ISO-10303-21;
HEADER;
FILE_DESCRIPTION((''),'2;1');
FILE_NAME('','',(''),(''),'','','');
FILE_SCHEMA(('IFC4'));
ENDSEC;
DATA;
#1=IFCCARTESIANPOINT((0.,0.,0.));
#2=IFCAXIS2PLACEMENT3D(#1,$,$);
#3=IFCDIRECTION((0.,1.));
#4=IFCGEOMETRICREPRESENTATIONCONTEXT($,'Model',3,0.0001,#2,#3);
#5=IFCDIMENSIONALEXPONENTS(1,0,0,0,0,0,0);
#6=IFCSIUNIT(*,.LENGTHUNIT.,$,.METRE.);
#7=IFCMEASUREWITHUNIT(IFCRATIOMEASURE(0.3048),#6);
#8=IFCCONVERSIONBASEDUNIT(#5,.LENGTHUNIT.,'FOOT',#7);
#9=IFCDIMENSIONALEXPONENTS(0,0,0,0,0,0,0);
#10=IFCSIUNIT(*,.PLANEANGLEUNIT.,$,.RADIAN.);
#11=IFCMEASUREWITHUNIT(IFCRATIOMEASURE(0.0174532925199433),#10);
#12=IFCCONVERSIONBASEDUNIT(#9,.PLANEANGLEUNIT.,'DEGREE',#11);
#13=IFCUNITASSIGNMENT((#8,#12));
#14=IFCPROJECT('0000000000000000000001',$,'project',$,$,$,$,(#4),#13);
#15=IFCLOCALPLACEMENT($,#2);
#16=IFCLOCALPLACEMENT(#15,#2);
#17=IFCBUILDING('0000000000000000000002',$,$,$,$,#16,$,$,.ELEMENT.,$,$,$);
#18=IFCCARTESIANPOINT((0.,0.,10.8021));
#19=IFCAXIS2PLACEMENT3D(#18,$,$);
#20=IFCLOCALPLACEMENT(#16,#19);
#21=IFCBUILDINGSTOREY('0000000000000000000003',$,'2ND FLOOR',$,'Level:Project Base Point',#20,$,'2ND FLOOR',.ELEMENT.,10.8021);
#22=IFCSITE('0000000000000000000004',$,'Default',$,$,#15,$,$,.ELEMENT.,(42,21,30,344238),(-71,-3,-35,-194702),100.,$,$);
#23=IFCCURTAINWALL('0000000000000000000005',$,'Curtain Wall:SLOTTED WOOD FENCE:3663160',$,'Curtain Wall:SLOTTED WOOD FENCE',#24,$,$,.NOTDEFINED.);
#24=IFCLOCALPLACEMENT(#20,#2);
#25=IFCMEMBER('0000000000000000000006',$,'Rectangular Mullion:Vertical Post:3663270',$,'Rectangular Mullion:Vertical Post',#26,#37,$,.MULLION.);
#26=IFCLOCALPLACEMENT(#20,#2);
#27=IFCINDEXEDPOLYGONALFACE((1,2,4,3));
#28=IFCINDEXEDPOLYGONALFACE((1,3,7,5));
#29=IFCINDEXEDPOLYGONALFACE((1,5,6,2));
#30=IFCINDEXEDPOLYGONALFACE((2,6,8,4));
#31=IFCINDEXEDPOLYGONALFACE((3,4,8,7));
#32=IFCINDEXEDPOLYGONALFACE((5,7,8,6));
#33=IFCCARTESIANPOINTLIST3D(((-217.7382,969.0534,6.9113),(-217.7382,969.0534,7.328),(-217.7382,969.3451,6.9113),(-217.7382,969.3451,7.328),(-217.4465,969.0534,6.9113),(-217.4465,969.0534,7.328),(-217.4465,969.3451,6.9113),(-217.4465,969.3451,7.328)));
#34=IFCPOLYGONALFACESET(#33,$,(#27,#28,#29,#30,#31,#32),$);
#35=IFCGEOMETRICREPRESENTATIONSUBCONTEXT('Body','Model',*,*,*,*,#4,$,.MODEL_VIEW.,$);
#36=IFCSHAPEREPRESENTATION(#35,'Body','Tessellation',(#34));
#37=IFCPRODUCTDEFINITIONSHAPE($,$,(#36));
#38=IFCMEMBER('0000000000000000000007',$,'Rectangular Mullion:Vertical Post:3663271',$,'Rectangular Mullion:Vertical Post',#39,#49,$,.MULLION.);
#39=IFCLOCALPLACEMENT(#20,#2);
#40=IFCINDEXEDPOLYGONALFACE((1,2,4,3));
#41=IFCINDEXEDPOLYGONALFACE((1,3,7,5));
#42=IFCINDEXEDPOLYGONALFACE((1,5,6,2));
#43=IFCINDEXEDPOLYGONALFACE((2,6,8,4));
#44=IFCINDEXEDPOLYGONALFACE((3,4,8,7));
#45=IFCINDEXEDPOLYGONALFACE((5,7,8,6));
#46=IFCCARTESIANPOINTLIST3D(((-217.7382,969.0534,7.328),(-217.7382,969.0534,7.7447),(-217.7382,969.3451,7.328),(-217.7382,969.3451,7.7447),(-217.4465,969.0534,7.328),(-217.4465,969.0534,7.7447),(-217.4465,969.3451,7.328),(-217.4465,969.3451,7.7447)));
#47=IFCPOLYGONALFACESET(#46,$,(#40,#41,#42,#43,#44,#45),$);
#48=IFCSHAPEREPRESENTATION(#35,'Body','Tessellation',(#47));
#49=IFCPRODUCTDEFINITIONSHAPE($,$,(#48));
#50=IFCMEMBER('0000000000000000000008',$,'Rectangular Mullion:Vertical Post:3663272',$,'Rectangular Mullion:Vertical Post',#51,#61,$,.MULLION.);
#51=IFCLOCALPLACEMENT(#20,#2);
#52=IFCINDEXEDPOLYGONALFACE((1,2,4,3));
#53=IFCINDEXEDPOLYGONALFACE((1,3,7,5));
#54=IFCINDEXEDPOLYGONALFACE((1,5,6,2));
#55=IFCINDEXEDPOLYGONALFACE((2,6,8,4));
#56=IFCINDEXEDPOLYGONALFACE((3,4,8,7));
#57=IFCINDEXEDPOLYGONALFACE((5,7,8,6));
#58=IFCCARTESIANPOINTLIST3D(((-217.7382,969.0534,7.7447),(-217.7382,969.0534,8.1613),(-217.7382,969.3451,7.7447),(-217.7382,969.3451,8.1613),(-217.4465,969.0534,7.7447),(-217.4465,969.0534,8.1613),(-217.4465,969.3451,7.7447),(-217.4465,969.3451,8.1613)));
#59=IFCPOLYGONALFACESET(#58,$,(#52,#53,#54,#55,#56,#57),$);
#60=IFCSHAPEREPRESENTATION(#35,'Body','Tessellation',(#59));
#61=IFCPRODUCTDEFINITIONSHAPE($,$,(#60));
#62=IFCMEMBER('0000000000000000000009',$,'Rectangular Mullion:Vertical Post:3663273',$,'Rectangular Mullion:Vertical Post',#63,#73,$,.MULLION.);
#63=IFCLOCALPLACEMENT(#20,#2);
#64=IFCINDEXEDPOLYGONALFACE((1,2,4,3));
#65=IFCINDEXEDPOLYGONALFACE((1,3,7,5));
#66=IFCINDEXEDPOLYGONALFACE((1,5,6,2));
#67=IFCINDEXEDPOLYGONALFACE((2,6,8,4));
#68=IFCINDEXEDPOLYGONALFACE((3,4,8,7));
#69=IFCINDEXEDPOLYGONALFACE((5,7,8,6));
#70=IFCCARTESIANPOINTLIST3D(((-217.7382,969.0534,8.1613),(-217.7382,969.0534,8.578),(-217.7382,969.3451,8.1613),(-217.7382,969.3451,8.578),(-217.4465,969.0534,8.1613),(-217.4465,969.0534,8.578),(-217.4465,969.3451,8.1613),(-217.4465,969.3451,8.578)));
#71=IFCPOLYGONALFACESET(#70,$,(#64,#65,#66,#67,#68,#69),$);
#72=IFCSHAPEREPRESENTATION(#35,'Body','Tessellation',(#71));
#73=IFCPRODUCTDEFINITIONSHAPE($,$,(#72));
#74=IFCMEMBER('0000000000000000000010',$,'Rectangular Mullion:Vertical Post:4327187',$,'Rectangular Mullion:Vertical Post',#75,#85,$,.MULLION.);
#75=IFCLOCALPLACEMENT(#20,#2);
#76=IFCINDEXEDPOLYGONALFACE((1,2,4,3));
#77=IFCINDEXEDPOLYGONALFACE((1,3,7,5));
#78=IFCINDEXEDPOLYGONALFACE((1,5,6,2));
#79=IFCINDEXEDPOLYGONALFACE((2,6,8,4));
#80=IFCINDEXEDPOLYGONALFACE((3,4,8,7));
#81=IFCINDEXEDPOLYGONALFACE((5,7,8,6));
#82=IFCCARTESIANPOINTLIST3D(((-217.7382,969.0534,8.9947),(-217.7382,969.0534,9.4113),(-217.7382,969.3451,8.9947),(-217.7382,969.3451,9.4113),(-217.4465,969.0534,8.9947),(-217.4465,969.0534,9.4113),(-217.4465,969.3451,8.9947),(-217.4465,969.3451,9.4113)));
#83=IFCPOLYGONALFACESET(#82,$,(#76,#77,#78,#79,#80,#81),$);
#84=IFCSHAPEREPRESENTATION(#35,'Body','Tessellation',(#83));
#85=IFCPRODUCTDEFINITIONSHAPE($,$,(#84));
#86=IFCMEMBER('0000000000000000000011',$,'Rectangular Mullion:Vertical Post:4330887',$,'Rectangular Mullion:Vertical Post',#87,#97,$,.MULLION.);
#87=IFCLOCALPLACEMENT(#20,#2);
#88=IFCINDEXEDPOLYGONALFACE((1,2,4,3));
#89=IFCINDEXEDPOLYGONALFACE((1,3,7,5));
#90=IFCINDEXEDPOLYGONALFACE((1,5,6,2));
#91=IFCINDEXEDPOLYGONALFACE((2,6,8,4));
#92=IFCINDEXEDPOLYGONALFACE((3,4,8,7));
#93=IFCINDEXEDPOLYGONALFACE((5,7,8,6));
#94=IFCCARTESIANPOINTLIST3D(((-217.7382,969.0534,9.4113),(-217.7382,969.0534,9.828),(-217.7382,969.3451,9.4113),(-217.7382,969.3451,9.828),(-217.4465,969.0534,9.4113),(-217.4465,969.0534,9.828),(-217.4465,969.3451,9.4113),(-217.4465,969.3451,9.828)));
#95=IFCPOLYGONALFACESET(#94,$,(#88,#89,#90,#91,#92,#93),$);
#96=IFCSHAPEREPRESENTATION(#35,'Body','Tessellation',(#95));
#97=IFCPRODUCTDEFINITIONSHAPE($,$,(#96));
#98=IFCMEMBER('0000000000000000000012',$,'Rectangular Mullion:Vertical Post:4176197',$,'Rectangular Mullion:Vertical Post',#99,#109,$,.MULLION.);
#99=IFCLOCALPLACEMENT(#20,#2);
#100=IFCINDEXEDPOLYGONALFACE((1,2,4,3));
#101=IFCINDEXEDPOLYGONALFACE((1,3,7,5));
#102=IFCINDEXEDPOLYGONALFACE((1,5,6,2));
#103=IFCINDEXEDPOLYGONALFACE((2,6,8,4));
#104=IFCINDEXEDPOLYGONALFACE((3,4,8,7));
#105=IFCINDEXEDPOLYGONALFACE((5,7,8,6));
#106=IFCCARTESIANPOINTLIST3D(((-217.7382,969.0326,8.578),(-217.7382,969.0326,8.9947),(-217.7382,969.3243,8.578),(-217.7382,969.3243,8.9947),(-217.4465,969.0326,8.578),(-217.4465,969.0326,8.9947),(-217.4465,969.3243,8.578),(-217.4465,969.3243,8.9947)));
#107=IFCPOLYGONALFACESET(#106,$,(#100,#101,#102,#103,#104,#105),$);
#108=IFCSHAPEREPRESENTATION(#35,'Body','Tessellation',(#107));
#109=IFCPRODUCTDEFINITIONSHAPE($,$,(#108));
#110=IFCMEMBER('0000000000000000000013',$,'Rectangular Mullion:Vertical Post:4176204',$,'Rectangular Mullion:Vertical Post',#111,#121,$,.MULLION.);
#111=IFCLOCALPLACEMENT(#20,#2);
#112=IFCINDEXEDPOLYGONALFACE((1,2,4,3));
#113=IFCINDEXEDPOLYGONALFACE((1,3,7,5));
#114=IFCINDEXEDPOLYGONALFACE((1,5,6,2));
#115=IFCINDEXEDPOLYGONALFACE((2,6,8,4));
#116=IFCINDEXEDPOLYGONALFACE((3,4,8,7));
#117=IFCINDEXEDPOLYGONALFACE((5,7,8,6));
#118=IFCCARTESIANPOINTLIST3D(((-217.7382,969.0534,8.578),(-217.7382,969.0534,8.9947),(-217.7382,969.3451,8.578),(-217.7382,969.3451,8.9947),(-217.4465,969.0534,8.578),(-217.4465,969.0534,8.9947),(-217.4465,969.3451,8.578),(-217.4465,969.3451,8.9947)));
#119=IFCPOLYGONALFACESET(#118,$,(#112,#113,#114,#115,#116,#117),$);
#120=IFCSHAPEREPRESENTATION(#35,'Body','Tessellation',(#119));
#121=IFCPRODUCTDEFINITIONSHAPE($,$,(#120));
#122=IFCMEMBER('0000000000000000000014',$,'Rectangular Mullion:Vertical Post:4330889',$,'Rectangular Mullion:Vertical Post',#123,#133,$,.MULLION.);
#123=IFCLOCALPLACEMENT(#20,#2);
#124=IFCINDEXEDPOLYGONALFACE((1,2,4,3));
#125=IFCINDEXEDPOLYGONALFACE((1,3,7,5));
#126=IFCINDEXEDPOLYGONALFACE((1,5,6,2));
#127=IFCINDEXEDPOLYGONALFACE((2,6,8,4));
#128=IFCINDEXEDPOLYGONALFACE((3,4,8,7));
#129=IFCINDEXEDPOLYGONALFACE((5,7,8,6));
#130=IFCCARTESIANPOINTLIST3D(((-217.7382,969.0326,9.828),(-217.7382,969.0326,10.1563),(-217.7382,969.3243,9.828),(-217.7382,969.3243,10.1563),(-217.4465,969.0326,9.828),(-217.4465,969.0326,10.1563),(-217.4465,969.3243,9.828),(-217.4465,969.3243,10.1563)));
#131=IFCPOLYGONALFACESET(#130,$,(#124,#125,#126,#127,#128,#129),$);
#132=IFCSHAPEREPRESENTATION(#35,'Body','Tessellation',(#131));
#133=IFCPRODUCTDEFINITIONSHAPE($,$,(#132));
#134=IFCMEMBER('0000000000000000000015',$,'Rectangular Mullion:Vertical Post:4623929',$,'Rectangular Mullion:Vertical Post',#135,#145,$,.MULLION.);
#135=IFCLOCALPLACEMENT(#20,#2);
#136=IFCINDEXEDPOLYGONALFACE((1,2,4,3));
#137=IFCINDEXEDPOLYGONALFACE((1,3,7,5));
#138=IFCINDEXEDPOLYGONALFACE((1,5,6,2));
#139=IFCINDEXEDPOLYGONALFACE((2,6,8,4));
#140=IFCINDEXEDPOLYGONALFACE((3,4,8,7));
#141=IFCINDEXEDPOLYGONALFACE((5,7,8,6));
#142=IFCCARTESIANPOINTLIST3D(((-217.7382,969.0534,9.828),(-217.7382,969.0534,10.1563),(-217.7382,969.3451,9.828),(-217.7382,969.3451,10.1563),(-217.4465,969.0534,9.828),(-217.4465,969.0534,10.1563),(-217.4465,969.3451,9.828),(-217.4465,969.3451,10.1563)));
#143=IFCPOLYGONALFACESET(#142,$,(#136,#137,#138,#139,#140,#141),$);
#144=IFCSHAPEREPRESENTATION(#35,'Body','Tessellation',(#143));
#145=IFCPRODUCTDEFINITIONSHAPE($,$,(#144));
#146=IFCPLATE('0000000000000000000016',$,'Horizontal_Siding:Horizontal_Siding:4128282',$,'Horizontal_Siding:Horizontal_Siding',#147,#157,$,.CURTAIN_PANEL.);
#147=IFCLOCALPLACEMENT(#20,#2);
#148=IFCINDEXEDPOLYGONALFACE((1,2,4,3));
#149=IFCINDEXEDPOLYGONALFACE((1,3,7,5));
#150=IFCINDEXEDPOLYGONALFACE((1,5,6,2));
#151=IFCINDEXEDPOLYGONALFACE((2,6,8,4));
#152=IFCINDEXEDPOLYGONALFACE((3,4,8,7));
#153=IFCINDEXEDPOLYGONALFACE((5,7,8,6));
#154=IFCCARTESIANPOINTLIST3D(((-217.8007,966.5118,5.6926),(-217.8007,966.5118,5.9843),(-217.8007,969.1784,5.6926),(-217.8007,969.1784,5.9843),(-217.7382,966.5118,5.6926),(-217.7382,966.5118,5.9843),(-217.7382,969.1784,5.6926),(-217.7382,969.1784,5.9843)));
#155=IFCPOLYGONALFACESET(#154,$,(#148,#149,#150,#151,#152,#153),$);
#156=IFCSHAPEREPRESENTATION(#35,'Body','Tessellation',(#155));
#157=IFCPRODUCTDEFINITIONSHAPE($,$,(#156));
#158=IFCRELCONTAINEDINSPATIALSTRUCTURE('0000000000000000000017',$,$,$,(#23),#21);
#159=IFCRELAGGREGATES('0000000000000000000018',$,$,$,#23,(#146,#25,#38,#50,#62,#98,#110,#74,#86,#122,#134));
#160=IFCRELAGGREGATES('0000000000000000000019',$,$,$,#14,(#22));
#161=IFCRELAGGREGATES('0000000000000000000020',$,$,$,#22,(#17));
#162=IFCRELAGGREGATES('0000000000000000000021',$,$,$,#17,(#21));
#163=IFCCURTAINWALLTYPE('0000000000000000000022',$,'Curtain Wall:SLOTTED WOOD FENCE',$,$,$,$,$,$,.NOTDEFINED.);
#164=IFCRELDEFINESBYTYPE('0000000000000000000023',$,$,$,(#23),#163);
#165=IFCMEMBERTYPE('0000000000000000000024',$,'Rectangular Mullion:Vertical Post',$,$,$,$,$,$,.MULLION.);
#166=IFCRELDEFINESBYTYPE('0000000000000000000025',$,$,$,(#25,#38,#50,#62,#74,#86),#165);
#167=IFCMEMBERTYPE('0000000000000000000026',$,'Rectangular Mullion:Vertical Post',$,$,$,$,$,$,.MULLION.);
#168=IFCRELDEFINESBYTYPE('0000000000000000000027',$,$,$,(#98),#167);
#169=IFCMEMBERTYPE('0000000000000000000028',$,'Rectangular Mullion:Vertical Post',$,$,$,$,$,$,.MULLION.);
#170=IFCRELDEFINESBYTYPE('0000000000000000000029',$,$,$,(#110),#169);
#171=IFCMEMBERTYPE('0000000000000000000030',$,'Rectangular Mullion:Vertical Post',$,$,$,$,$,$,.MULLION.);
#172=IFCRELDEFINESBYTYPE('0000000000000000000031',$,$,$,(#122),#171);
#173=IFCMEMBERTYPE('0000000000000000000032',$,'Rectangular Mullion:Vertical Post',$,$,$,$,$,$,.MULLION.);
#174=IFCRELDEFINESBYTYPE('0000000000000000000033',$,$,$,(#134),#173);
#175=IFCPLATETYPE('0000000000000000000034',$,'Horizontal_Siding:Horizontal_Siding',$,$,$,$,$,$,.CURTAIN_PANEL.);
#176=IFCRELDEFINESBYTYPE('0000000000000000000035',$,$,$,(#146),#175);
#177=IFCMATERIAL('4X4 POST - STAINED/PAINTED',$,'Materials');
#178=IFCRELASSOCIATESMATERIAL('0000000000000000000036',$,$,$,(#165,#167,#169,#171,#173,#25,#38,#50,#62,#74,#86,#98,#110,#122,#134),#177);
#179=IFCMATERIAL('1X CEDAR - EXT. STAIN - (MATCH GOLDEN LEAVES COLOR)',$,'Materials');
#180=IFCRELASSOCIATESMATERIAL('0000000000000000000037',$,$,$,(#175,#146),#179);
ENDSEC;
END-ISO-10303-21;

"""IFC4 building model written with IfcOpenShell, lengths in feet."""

from ifc_helpers import new_model, entity, si_unit, converted_unit, direction, frame, origin, origin_2d_with_axis, place, context, subcontext, project, spatial, rectangle, extrude, source, transform, mapped, material, material_profile, profile_set, profile_usage, type_object, type_shapes, element, aggregate, save


model = new_model("IFC4")

# Units and contexts
model_context = context("Model", 3, precision=0.0001, world=origin(), true_north=direction((0.0, 1.0)))
body_context = subcontext(model_context, "Body", "Model", "MODEL_VIEW")
ifc_project = project(units=[converted_unit("LENGTHUNIT", "FOOT", entity("IfcRatioMeasure", 0.3048), si_unit("LENGTHUNIT", "METRE"), dimensions=[1, 0, 0, 0, 0, 0, 0]), converted_unit("PLANEANGLEUNIT", "DEGREE", entity("IfcRatioMeasure", 0.0174532925199433), si_unit("PLANEANGLEUNIT", "RADIAN"), dimensions=[0, 0, 0, 0, 0, 0, 0])], contexts=[model_context])

# Site, building, storey
site_placement = place(None, origin())
site = spatial("IfcSite", under=ifc_project, at=site_placement, Name="Default", CompositionType="ELEMENT", RefLatitude=(42, 21, 30, 344238), RefLongitude=(-71, -3, -35, -194702), RefElevation=100.0)
building_placement = place(site_placement, origin())
building = spatial("IfcBuilding", under=site, at=building_placement, CompositionType="ELEMENT")
storey_placement = place(building_placement, frame((0.0, 0.0, 10.8021)))
storey = spatial("IfcBuildingStorey", under=building, at=storey_placement, Name="2ND FLOOR", ObjectType="Level:Project Base Point", LongName="2ND FLOOR", CompositionType="ELEMENT", Elevation=10.8021)

# Curtain wall, members, plate
curtain_wall_type = type_object("IfcCurtainWallType", Name="Curtain Wall:SLOTTED WOOD FENCE", PredefinedType="NOTDEFINED")
curtain_wall_placement = place(storey_placement, frame((0.0, 0.0, -10.8021)))
curtain_wall = element("IfcCurtainWall", 1, at=curtain_wall_placement, inside=storey, type_object=curtain_wall_type, Name="Curtain Wall:SLOTTED WOOD FENCE:3663160", ObjectType="Curtain Wall:SLOTTED WOOD FENCE", PredefinedType="NOTDEFINED")
ifc_material_1 = material(Name="4X4 POST - STAINED/PAINTED", Category="Materials")
ifc_material_profile = material_profile(ifc_material_1, rectangle(XDim=0.2917, YDim=0.2917, at=origin_2d_with_axis()), Name="Vertical Post")
ifc_profile_set = profile_set([ifc_material_profile], Name="Vertical Post")
member_type_1 = type_object("IfcMemberType", Name="Rectangular Mullion:Vertical Post", PredefinedType="MULLION", material=ifc_profile_set)
shared_shape_1 = source(origin(), body_context, "Body", "SweptSolid", [
    extrude(rectangle(XDim=0.2917, YDim=0.2917, at=origin_2d_with_axis()), frame((-0.1458, -0.2083, -0.4167), z_axis=(0.0, 0.0, 1.0), x_axis=(0.0, -1.0, 0.0)), (0.0, 0.0, 1.0), 0.4167),
])
type_shapes(member_type_1, [shared_shape_1])
ifc_profile_usage_1 = profile_usage(ifc_profile_set)
member_1_placement = place(storey_placement, frame((-217.8007, 969.3451, 7.328), z_axis=(0.0, 0.0, 1.0), x_axis=(0.0, 1.0, 0.0)))
member_1 = element("IfcMember", 2, at=member_1_placement, type_object=member_type_1, material=ifc_profile_usage_1, Name="Rectangular Mullion:Vertical Post:3663270", ObjectType="Rectangular Mullion:Vertical Post", PredefinedType="MULLION", context=body_context, shape_type="MappedRepresentation", body=[
    mapped(shared_shape_1, transform((0.0, 0.0, 0.0), scale=1.0)),
])
ifc_profile_usage_2 = profile_usage(ifc_profile_set)
member_2_placement = place(storey_placement, frame((-217.8007, 969.3451, 7.7447), z_axis=(0.0, 0.0, 1.0), x_axis=(0.0, 1.0, 0.0)))
member_2 = element("IfcMember", 3, at=member_2_placement, type_object=member_type_1, material=ifc_profile_usage_2, Name="Rectangular Mullion:Vertical Post:3663271", ObjectType="Rectangular Mullion:Vertical Post", PredefinedType="MULLION", context=body_context, shape_type="MappedRepresentation", body=[
    mapped(shared_shape_1, transform((0.0, 0.0, 0.0), scale=1.0)),
])
ifc_profile_usage_3 = profile_usage(ifc_profile_set)
member_3_placement = place(storey_placement, frame((-217.8007, 969.3451, 8.1613), z_axis=(0.0, 0.0, 1.0), x_axis=(0.0, 1.0, 0.0)))
member_3 = element("IfcMember", 4, at=member_3_placement, type_object=member_type_1, material=ifc_profile_usage_3, Name="Rectangular Mullion:Vertical Post:3663272", ObjectType="Rectangular Mullion:Vertical Post", PredefinedType="MULLION", context=body_context, shape_type="MappedRepresentation", body=[
    mapped(shared_shape_1, transform((0.0, 0.0, 0.0), scale=1.0)),
])
ifc_profile_usage_4 = profile_usage(ifc_profile_set)
member_4_placement = place(storey_placement, frame((-217.8007, 969.3451, 8.578), z_axis=(0.0, 0.0, 1.0), x_axis=(0.0, 1.0, 0.0)))
member_4 = element("IfcMember", 5, at=member_4_placement, type_object=member_type_1, material=ifc_profile_usage_4, Name="Rectangular Mullion:Vertical Post:3663273", ObjectType="Rectangular Mullion:Vertical Post", PredefinedType="MULLION", context=body_context, shape_type="MappedRepresentation", body=[
    mapped(shared_shape_1, transform((0.0, 0.0, 0.0), scale=1.0)),
])
ifc_profile_usage_5 = profile_usage(ifc_profile_set)
member_5_placement = place(storey_placement, frame((-217.8007, 969.3451, 9.4113), z_axis=(0.0, 0.0, 1.0), x_axis=(0.0, 1.0, 0.0)))
member_5 = element("IfcMember", 6, at=member_5_placement, type_object=member_type_1, material=ifc_profile_usage_5, Name="Rectangular Mullion:Vertical Post:4327187", ObjectType="Rectangular Mullion:Vertical Post", PredefinedType="MULLION", context=body_context, shape_type="MappedRepresentation", body=[
    mapped(shared_shape_1, transform((0.0, 0.0, 0.0), scale=1.0)),
])
ifc_profile_usage_6 = profile_usage(ifc_profile_set)
member_6_placement = place(storey_placement, frame((-217.8007, 969.3451, 9.828), z_axis=(0.0, 0.0, 1.0), x_axis=(0.0, 1.0, 0.0)))
member_6 = element("IfcMember", 7, at=member_6_placement, type_object=member_type_1, material=ifc_profile_usage_6, Name="Rectangular Mullion:Vertical Post:4330887", ObjectType="Rectangular Mullion:Vertical Post", PredefinedType="MULLION", context=body_context, shape_type="MappedRepresentation", body=[
    mapped(shared_shape_1, transform((0.0, 0.0, 0.0), scale=1.0)),
])
ifc_profile_usage_7 = profile_usage(ifc_profile_set)
member_type_2 = type_object("IfcMemberType", Name="Rectangular Mullion:Vertical Post", PredefinedType="MULLION", material=ifc_profile_set)
shared_shape_2 = source(origin(), body_context, "Body", "SweptSolid", [
    extrude(rectangle(XDim=0.2917, YDim=0.2917, at=origin_2d_with_axis()), frame((0.0, -0.2083, -0.4167), z_axis=(0.0, 0.0, 1.0), x_axis=(0.0, -1.0, 0.0)), (0.0, 0.0, 1.0), 0.4167),
])
type_shapes(member_type_2, [shared_shape_2])
member_7_placement = place(storey_placement, frame((-217.8007, 969.1784, 8.578), z_axis=(0.0, 0.0, -1.0), x_axis=(0.0, -1.0, 0.0)))
member_7 = element("IfcMember", 8, at=member_7_placement, type_object=member_type_2, material=ifc_profile_usage_7, Name="Rectangular Mullion:Vertical Post:4176197", ObjectType="Rectangular Mullion:Vertical Post", PredefinedType="MULLION", context=body_context, shape_type="MappedRepresentation", body=[
    mapped(shared_shape_2, transform((0.0, 0.0, 0.0), scale=1.0)),
])
ifc_profile_usage_8 = profile_usage(ifc_profile_set)
member_type_3 = type_object("IfcMemberType", Name="Rectangular Mullion:Vertical Post", PredefinedType="MULLION", material=ifc_profile_set)
shared_shape_3 = source(origin(), body_context, "Body", "SweptSolid", [
    extrude(rectangle(XDim=0.2917, YDim=0.2917, at=origin_2d_with_axis()), frame((-0.1458, -0.2083, -0.4167), z_axis=(0.0, 0.0, 1.0), x_axis=(0.0, -1.0, 0.0)), (0.0, 0.0, 1.0), 0.4167),
])
type_shapes(member_type_3, [shared_shape_3])
member_8_placement = place(storey_placement, frame((-217.8007, 969.3451, 8.9947), z_axis=(0.0, 0.0, 1.0), x_axis=(0.0, 1.0, 0.0)))
member_8 = element("IfcMember", 9, at=member_8_placement, type_object=member_type_3, material=ifc_profile_usage_8, Name="Rectangular Mullion:Vertical Post:4176204", ObjectType="Rectangular Mullion:Vertical Post", PredefinedType="MULLION", context=body_context, shape_type="MappedRepresentation", body=[
    mapped(shared_shape_3, transform((0.0, 0.0, 0.0), scale=1.0)),
])
ifc_profile_usage_9 = profile_usage(ifc_profile_set)
member_type_4 = type_object("IfcMemberType", Name="Rectangular Mullion:Vertical Post", PredefinedType="MULLION", material=ifc_profile_set)
shared_shape_4 = source(origin(), body_context, "Body", "SweptSolid", [
    extrude(rectangle(XDim=0.2917, YDim=0.2917, at=origin_2d_with_axis()), frame((0.0, -0.2083, -0.3282), z_axis=(0.0, 0.0, 1.0), x_axis=(0.0, -1.0, 0.0)), (0.0, 0.0, 1.0), 0.3282),
])
type_shapes(member_type_4, [shared_shape_4])
member_9_placement = place(storey_placement, frame((-217.8007, 969.1784, 9.828), z_axis=(0.0, 0.0, -1.0), x_axis=(0.0, -1.0, 0.0)))
member_9 = element("IfcMember", 10, at=member_9_placement, type_object=member_type_4, material=ifc_profile_usage_9, Name="Rectangular Mullion:Vertical Post:4330889", ObjectType="Rectangular Mullion:Vertical Post", PredefinedType="MULLION", context=body_context, shape_type="MappedRepresentation", body=[
    mapped(shared_shape_4, transform((0.0, 0.0, 0.0), scale=1.0)),
])
ifc_profile_usage_10 = profile_usage(ifc_profile_set)
member_type_5 = type_object("IfcMemberType", Name="Rectangular Mullion:Vertical Post", PredefinedType="MULLION", material=ifc_profile_set)
shared_shape_5 = source(origin(), body_context, "Body", "SweptSolid", [
    extrude(rectangle(XDim=0.2917, YDim=0.2917, at=origin_2d_with_axis()), frame((-0.1458, -0.2083, -0.3282), z_axis=(0.0, 0.0, 1.0), x_axis=(0.0, -1.0, 0.0)), (0.0, 0.0, 1.0), 0.3282),
])
type_shapes(member_type_5, [shared_shape_5])
member_10_placement = place(storey_placement, frame((-217.8007, 969.3451, 10.1562), z_axis=(0.0, 0.0, 1.0), x_axis=(0.0, 1.0, 0.0)))
member_10 = element("IfcMember", 11, at=member_10_placement, type_object=member_type_5, material=ifc_profile_usage_10, Name="Rectangular Mullion:Vertical Post:4623929", ObjectType="Rectangular Mullion:Vertical Post", PredefinedType="MULLION", context=body_context, shape_type="MappedRepresentation", body=[
    mapped(shared_shape_5, transform((0.0, 0.0, 0.0), scale=1.0)),
])
ifc_material_2 = material(Name="1X CEDAR - EXT. STAIN - (MATCH GOLDEN LEAVES COLOR)", Category="Materials")
plate_type_1 = type_object("IfcPlateType", Name="Horizontal_Siding:Horizontal_Siding", PredefinedType="CURTAIN_PANEL", material=ifc_material_2)
shared_shape_6 = source(origin(), body_context, "Body", "SweptSolid", [
    extrude(rectangle(XDim=2.6667, YDim=0.0625, at=origin_2d_with_axis()), frame((1.3333, 0.0312, 0.0), z_axis=(0.0, 0.0, 1.0), x_axis=(-1.0, 0.0, 0.0)), (0.0, 0.0, 1.0), 0.2917),
])
type_shapes(plate_type_1, [shared_shape_6])
plate_1_placement = place(curtain_wall_placement, frame((-217.8007, 969.1784, 16.4947), z_axis=(0.0, 0.0, 1.0), x_axis=(0.0, -1.0, 0.0)))
plate_1 = element("IfcPlate", 12, at=plate_1_placement, type_object=plate_type_1, material=ifc_material_2, Name="Horizontal_Siding:Horizontal_Siding:4128282", ObjectType="Horizontal_Siding:Horizontal_Siding", PredefinedType="CURTAIN_PANEL", context=body_context, shape_type="MappedRepresentation", body=[
    mapped(shared_shape_6, transform((0.0, 0.0, 0.0), scale=1.0)),
])
aggregate(curtain_wall, [plate_1, member_1, member_2, member_3, member_4, member_7, member_8, member_5, member_6, member_9, member_10])

save(model, "model.ifc")
